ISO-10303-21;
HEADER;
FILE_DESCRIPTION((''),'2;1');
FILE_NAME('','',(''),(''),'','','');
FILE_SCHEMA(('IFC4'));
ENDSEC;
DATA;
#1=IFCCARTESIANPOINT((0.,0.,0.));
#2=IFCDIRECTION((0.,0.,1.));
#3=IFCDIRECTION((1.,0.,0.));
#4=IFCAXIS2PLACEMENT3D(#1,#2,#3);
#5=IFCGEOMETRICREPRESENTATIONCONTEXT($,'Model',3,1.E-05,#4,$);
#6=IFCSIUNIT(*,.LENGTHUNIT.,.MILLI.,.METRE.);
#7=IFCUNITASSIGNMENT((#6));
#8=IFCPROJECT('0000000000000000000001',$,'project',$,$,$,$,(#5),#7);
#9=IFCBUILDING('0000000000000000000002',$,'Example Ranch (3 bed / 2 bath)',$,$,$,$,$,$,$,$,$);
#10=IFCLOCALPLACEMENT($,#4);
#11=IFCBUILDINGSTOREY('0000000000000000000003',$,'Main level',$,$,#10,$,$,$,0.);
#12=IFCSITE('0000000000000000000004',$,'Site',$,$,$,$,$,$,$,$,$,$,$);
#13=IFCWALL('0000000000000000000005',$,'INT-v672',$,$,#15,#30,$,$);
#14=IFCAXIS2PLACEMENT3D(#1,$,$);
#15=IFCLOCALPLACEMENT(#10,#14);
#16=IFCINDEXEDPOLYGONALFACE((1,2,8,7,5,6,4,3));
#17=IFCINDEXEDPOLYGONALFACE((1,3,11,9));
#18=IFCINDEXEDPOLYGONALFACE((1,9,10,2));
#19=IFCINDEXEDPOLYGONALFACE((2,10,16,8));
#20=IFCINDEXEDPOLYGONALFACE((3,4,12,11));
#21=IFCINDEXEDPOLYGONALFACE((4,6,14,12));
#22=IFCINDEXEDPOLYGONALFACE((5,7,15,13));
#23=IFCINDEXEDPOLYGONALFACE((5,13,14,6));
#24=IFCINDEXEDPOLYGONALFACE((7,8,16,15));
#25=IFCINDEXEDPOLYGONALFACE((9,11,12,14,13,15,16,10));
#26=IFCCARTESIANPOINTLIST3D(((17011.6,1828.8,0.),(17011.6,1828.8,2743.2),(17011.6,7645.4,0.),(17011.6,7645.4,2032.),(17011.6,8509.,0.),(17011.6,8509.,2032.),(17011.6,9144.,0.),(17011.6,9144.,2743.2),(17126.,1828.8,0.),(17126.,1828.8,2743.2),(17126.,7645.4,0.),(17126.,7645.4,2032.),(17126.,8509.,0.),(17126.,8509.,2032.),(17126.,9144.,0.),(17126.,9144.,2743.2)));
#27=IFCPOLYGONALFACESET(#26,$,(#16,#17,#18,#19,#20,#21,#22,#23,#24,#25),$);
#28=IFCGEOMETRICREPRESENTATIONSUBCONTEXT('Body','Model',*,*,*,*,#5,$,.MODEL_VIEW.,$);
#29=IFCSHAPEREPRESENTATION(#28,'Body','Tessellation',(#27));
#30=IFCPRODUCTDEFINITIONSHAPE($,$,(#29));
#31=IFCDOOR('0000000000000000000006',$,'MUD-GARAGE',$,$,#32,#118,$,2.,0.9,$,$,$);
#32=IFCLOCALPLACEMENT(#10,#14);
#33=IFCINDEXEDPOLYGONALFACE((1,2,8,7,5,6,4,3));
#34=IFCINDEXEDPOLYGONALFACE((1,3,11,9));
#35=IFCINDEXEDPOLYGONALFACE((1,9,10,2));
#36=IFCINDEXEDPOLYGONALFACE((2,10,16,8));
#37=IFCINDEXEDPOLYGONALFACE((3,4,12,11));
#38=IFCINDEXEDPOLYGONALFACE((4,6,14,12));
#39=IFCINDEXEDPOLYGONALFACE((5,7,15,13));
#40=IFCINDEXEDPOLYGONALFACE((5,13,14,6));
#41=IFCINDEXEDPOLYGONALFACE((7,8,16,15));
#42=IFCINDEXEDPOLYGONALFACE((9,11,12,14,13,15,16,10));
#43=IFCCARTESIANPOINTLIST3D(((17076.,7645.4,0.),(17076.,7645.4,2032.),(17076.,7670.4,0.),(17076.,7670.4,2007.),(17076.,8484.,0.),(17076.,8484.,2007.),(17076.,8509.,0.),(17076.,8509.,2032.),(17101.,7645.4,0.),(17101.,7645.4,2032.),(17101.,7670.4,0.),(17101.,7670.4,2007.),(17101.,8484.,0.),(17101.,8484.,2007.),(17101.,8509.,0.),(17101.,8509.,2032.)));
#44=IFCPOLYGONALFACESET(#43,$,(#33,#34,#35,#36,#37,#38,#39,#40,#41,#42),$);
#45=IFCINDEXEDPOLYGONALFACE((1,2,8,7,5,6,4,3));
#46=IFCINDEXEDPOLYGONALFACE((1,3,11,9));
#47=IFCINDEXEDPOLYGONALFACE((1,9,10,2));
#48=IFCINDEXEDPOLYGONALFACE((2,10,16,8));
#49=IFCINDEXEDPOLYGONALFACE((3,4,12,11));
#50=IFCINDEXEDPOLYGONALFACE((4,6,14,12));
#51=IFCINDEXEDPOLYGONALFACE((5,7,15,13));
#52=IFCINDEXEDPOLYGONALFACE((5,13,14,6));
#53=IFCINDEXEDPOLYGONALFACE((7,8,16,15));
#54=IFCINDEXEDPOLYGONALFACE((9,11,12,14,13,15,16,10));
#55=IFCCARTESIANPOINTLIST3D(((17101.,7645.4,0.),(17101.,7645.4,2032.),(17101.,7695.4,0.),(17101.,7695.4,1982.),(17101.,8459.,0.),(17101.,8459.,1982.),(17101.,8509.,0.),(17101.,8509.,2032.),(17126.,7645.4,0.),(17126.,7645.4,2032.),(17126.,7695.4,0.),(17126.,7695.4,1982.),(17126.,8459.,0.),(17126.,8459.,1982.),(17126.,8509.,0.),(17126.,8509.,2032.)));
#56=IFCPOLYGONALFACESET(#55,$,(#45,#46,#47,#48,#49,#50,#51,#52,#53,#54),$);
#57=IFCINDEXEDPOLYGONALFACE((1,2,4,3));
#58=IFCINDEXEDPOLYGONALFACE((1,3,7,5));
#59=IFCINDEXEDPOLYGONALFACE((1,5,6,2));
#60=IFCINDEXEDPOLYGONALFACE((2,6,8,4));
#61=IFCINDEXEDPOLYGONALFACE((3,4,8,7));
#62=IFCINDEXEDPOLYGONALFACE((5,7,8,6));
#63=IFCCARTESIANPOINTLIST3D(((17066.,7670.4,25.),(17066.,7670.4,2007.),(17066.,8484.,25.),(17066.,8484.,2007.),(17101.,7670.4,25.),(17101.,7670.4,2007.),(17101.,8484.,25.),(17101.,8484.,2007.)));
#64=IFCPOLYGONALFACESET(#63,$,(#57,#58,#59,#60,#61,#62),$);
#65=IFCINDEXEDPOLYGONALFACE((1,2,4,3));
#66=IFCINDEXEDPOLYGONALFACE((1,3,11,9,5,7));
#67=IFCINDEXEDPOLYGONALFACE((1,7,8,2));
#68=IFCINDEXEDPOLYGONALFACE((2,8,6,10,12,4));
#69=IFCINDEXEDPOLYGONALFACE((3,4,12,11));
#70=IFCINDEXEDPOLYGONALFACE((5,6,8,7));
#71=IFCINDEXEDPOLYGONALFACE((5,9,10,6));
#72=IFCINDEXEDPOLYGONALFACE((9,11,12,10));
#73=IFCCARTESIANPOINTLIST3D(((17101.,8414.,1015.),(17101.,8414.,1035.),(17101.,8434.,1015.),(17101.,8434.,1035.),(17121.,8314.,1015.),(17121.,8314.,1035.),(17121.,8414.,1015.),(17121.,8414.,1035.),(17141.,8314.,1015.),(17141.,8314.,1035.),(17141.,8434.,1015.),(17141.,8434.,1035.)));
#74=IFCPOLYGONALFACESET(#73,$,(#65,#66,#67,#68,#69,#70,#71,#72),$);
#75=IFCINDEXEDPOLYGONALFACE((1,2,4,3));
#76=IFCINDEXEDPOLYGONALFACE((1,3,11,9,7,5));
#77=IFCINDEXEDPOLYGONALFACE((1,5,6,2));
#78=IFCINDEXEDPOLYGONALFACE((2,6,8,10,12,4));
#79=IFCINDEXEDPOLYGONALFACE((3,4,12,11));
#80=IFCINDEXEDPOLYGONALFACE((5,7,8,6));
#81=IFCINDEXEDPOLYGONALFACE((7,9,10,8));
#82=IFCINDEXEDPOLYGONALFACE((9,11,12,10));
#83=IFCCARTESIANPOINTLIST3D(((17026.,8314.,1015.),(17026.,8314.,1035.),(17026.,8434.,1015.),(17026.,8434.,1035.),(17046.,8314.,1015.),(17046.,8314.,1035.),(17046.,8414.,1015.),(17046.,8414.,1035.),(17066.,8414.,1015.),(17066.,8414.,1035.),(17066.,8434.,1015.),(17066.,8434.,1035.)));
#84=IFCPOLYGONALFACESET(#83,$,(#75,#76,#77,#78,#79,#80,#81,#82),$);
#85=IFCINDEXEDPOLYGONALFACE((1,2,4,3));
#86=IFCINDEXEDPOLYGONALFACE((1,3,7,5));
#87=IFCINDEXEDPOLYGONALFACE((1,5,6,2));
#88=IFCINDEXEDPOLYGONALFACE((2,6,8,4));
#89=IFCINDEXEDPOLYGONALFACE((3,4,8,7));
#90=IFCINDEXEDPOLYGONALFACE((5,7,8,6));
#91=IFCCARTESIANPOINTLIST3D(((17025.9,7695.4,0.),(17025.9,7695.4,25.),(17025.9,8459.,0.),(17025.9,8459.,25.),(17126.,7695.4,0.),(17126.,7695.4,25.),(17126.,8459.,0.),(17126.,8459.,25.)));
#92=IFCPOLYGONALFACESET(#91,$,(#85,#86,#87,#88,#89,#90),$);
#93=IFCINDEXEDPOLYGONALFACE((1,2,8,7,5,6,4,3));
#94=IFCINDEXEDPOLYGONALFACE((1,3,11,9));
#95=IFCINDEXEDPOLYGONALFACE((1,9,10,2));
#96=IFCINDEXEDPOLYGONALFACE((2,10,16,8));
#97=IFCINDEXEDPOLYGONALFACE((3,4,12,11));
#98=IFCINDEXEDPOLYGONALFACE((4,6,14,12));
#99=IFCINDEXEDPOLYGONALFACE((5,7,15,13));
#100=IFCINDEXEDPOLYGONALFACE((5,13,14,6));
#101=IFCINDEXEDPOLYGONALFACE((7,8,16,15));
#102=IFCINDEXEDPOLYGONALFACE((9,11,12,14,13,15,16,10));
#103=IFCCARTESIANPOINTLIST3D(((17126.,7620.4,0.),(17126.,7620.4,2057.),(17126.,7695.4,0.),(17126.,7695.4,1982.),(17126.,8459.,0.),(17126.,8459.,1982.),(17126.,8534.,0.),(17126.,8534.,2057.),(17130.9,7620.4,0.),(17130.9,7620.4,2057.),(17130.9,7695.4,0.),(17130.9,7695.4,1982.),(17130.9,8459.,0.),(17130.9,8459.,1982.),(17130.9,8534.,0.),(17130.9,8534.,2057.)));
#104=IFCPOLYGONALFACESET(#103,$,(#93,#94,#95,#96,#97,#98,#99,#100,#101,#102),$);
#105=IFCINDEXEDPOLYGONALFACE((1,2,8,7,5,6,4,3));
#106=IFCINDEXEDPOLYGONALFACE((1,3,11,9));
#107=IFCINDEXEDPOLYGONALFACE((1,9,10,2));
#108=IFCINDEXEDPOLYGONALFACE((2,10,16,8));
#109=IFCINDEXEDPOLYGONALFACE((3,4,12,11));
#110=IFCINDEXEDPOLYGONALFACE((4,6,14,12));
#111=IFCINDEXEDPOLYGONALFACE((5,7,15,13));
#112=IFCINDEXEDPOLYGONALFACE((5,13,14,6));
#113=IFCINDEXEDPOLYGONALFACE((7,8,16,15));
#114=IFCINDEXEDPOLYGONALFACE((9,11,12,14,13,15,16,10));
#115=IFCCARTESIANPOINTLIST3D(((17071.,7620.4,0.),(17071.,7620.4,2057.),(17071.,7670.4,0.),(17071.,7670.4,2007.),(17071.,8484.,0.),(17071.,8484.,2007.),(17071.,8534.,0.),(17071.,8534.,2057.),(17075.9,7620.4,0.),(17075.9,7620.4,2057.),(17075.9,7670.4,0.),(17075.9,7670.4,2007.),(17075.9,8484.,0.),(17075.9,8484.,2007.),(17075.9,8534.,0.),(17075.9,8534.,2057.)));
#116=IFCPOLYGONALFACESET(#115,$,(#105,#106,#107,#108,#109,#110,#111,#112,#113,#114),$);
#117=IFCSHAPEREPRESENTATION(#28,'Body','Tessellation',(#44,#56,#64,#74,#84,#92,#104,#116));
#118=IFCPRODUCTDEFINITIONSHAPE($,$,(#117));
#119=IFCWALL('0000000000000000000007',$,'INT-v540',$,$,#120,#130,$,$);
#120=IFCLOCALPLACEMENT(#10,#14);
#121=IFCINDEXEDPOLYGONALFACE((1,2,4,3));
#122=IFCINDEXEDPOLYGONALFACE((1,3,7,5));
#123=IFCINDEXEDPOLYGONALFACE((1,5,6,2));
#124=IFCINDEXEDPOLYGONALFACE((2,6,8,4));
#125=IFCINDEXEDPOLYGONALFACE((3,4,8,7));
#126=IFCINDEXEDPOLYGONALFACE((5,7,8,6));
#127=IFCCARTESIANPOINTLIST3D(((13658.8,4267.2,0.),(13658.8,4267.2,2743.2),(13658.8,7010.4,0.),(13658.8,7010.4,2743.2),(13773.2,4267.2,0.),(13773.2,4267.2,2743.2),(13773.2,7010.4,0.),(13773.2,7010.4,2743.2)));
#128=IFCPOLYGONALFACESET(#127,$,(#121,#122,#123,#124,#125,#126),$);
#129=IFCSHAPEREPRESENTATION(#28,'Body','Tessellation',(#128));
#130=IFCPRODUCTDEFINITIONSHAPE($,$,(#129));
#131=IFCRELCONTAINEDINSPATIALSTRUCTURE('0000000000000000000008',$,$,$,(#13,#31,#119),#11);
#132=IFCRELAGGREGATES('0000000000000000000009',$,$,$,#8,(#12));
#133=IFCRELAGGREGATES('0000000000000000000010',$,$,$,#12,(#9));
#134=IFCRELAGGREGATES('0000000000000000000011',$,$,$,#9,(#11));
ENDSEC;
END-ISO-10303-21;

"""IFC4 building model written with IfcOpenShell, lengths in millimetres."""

from ifc_helpers import new_model, si_unit, frame, origin_with_axes, place, context, subcontext, project, spatial, line, indexed_curve, outline, extrude, element, fill, save


model = new_model("IFC4")

# Units and contexts
model_context = context("Model", 3, precision=1e-05, world=origin_with_axes())
body_context = subcontext(model_context, "Body", "Model", "MODEL_VIEW")
ifc_project = project(units=[si_unit("LENGTHUNIT", "METRE", prefix="MILLI")], contexts=[model_context])

# Site, building, storey
site = spatial("IfcSite", under=ifc_project, Name="Site")
building = spatial("IfcBuilding", under=site, Name="Example Ranch (3 bed / 2 bath)")
storey_placement = place(None, origin_with_axes())
storey = spatial("IfcBuildingStorey", under=building, at=storey_placement, Name="Main level", Elevation=0.0)

# Wall, opening, door
wall_1_placement = place(storey_placement, frame((17126.0, 1828.8, 0.0), z_axis=(0.0, 0.0, 1.0), x_axis=(0.0, 1.0, 0.0)))
wall_1 = element("IfcWall", 1, at=wall_1_placement, inside=storey, Name="INT-v672", context=body_context, shape_type="SweptSolid", body=[
    extrude(outline(indexed_curve([(0.0, 0.0), (0.0, 114.3), (7315.2, 114.3), (7315.2, 0.0), (0.0, 0.0)], self_intersect=False)), origin_with_axes(), (0.0, 0.0, 1.0), 2743.2),
])
opening_1_placement = place(wall_1_placement, frame((5816.6, 0.0, 0.0), z_axis=(0.0, 0.0, 1.0), x_axis=(1.0, 0.0, 0.0)))
opening_1 = element("IfcOpeningElement", 2, at=opening_1_placement, cuts=wall_1, context=body_context, shape_type="SweptSolid", body=[
    extrude(outline(indexed_curve([(0.0, 0.0), (0.0, 114.3), (863.6, 114.3), (863.6, 0.0), (0.0, 0.0)], self_intersect=False)), origin_with_axes(), (0.0, 0.0, 1.0), 2032.0),
])
door_1_placement = place(storey_placement, frame((17126.0, 7645.4, 0.0), z_axis=(0.0, 0.0, 1.0), x_axis=(0.0, 1.0, 0.0)))
door_1 = element("IfcDoor", 3, at=door_1_placement, inside=storey, Name="MUD-GARAGE", OverallHeight=2.0, OverallWidth=0.9, context=body_context, shape_type="SweptSolid", body=[
    extrude(outline(indexed_curve([(0.0, 0.0), (0.0, 2032.0), (863.6, 2032.0), (863.6, 0.0), (838.6, 0.0), (838.6, 2007.0), (25.0, 2007.0), (25.0, 0.0)], segments=[line(1, 2, 3, 4, 5, 6, 7, 8, 1)])), frame((0.0, 25.0, 0.0), z_axis=(0.0, -1.0, 0.0), x_axis=(1.0, 0.0, 0.0)), (0.0, 0.0, -1.0), 25.0),
    extrude(outline(indexed_curve([(0.0, 0.0), (0.0, 2032.0), (863.6, 2032.0), (863.6, 0.0), (813.6, 0.0), (813.6, 1982.0), (50.0, 1982.0), (50.0, 0.0)], segments=[line(1, 2, 3, 4, 5, 6, 7, 8, 1)])), frame((0.0, 0.0, 0.0), z_axis=(0.0, -1.0, 0.0), x_axis=(1.0, 0.0, 0.0)), (0.0, 0.0, -1.0), 25.0),
    extrude(outline(indexed_curve([(0.0, 0.0), (813.6, 0.0), (813.6, 35.0), (0.0, 35.0)], segments=[line(1, 2, 3, 4, 1)])), frame((25.0, 25.0, 25.0), z_axis=(0.0, 0.0, 1.0), x_axis=(1.0, 0.0, 0.0)), (0.0, 0.0, 1.0), 1982.0),
    extrude(outline(indexed_curve([(0.0, 0.0), (0.0, -40.0), (-120.0, -40.0), (-120.0, -20.0), (-20.0, -20.0), (-20.0, 0.0)], segments=[line(1, 2, 3, 4, 5, 6, 1)])), frame((788.6, 25.0, 1015.0), z_axis=(0.0, 0.0, 1.0), x_axis=(1.0, 0.0, 0.0)), (0.0, 0.0, 1.0), 20.0),
    extrude(outline(indexed_curve([(0.0, 0.0), (0.0, 40.0), (-120.0, 40.0), (-120.0, 20.0), (-20.0, 20.0), (-20.0, 0.0)], segments=[line(1, 2, 3, 4, 5, 6, 1)])), frame((788.6, 60.0, 1015.0), z_axis=(0.0, 0.0, 1.0), x_axis=(1.0, 0.0, 0.0)), (0.0, 0.0, 1.0), 20.0),
    extrude(outline(indexed_curve([(0.0, 0.0), (763.6, 0.0), (763.6, 100.0), (0.0, 100.0)], segments=[line(1, 2, 3, 4, 1)])), frame((50.0, 0.0, 0.0), z_axis=(0.0, 0.0, 1.0), x_axis=(1.0, 0.0, 0.0)), (0.0, 0.0, 1.0), 25.0),
    extrude(outline(indexed_curve([(0.0, 0.0), (0.0, 2057.0), (913.6, 2057.0), (913.6, 0.0), (838.6, 0.0), (838.6, 1982.0), (75.0, 1982.0), (75.0, 0.0)], segments=[line(1, 2, 3, 4, 5, 6, 7, 8, 1)])), frame((-25.0, -5.0, 0.0), z_axis=(0.0, -1.0, 0.0), x_axis=(1.0, 0.0, 0.0)), (0.0, 0.0, -1.0), 5.0),
    extrude(outline(indexed_curve([(0.0, 0.0), (0.0, 2057.0), (913.6, 2057.0), (913.6, 0.0), (863.6, 0.0), (863.6, 2007.0), (50.0, 2007.0), (50.0, 0.0)], segments=[line(1, 2, 3, 4, 5, 6, 7, 8, 1)])), frame((-25.0, 50.0, 0.0), z_axis=(0.0, -1.0, 0.0), x_axis=(1.0, 0.0, 0.0)), (0.0, 0.0, -1.0), 5.0),
])
fill(opening_1, door_1)

# Wall
wall_2_placement = place(storey_placement, frame((13773.1, 4267.2, 0.0), z_axis=(0.0, 0.0, 1.0), x_axis=(0.0, 1.0, 0.0)))
element("IfcWall", 4, at=wall_2_placement, inside=storey, Name="INT-v540", context=body_context, shape_type="SweptSolid", body=[
    extrude(outline(indexed_curve([(0.0, 0.0), (0.0, 114.3), (2743.2, 114.3), (2743.2, 0.0), (0.0, 0.0)], self_intersect=False)), origin_with_axes(), (0.0, 0.0, 1.0), 2743.2),
])

save(model, "model.ifc")
